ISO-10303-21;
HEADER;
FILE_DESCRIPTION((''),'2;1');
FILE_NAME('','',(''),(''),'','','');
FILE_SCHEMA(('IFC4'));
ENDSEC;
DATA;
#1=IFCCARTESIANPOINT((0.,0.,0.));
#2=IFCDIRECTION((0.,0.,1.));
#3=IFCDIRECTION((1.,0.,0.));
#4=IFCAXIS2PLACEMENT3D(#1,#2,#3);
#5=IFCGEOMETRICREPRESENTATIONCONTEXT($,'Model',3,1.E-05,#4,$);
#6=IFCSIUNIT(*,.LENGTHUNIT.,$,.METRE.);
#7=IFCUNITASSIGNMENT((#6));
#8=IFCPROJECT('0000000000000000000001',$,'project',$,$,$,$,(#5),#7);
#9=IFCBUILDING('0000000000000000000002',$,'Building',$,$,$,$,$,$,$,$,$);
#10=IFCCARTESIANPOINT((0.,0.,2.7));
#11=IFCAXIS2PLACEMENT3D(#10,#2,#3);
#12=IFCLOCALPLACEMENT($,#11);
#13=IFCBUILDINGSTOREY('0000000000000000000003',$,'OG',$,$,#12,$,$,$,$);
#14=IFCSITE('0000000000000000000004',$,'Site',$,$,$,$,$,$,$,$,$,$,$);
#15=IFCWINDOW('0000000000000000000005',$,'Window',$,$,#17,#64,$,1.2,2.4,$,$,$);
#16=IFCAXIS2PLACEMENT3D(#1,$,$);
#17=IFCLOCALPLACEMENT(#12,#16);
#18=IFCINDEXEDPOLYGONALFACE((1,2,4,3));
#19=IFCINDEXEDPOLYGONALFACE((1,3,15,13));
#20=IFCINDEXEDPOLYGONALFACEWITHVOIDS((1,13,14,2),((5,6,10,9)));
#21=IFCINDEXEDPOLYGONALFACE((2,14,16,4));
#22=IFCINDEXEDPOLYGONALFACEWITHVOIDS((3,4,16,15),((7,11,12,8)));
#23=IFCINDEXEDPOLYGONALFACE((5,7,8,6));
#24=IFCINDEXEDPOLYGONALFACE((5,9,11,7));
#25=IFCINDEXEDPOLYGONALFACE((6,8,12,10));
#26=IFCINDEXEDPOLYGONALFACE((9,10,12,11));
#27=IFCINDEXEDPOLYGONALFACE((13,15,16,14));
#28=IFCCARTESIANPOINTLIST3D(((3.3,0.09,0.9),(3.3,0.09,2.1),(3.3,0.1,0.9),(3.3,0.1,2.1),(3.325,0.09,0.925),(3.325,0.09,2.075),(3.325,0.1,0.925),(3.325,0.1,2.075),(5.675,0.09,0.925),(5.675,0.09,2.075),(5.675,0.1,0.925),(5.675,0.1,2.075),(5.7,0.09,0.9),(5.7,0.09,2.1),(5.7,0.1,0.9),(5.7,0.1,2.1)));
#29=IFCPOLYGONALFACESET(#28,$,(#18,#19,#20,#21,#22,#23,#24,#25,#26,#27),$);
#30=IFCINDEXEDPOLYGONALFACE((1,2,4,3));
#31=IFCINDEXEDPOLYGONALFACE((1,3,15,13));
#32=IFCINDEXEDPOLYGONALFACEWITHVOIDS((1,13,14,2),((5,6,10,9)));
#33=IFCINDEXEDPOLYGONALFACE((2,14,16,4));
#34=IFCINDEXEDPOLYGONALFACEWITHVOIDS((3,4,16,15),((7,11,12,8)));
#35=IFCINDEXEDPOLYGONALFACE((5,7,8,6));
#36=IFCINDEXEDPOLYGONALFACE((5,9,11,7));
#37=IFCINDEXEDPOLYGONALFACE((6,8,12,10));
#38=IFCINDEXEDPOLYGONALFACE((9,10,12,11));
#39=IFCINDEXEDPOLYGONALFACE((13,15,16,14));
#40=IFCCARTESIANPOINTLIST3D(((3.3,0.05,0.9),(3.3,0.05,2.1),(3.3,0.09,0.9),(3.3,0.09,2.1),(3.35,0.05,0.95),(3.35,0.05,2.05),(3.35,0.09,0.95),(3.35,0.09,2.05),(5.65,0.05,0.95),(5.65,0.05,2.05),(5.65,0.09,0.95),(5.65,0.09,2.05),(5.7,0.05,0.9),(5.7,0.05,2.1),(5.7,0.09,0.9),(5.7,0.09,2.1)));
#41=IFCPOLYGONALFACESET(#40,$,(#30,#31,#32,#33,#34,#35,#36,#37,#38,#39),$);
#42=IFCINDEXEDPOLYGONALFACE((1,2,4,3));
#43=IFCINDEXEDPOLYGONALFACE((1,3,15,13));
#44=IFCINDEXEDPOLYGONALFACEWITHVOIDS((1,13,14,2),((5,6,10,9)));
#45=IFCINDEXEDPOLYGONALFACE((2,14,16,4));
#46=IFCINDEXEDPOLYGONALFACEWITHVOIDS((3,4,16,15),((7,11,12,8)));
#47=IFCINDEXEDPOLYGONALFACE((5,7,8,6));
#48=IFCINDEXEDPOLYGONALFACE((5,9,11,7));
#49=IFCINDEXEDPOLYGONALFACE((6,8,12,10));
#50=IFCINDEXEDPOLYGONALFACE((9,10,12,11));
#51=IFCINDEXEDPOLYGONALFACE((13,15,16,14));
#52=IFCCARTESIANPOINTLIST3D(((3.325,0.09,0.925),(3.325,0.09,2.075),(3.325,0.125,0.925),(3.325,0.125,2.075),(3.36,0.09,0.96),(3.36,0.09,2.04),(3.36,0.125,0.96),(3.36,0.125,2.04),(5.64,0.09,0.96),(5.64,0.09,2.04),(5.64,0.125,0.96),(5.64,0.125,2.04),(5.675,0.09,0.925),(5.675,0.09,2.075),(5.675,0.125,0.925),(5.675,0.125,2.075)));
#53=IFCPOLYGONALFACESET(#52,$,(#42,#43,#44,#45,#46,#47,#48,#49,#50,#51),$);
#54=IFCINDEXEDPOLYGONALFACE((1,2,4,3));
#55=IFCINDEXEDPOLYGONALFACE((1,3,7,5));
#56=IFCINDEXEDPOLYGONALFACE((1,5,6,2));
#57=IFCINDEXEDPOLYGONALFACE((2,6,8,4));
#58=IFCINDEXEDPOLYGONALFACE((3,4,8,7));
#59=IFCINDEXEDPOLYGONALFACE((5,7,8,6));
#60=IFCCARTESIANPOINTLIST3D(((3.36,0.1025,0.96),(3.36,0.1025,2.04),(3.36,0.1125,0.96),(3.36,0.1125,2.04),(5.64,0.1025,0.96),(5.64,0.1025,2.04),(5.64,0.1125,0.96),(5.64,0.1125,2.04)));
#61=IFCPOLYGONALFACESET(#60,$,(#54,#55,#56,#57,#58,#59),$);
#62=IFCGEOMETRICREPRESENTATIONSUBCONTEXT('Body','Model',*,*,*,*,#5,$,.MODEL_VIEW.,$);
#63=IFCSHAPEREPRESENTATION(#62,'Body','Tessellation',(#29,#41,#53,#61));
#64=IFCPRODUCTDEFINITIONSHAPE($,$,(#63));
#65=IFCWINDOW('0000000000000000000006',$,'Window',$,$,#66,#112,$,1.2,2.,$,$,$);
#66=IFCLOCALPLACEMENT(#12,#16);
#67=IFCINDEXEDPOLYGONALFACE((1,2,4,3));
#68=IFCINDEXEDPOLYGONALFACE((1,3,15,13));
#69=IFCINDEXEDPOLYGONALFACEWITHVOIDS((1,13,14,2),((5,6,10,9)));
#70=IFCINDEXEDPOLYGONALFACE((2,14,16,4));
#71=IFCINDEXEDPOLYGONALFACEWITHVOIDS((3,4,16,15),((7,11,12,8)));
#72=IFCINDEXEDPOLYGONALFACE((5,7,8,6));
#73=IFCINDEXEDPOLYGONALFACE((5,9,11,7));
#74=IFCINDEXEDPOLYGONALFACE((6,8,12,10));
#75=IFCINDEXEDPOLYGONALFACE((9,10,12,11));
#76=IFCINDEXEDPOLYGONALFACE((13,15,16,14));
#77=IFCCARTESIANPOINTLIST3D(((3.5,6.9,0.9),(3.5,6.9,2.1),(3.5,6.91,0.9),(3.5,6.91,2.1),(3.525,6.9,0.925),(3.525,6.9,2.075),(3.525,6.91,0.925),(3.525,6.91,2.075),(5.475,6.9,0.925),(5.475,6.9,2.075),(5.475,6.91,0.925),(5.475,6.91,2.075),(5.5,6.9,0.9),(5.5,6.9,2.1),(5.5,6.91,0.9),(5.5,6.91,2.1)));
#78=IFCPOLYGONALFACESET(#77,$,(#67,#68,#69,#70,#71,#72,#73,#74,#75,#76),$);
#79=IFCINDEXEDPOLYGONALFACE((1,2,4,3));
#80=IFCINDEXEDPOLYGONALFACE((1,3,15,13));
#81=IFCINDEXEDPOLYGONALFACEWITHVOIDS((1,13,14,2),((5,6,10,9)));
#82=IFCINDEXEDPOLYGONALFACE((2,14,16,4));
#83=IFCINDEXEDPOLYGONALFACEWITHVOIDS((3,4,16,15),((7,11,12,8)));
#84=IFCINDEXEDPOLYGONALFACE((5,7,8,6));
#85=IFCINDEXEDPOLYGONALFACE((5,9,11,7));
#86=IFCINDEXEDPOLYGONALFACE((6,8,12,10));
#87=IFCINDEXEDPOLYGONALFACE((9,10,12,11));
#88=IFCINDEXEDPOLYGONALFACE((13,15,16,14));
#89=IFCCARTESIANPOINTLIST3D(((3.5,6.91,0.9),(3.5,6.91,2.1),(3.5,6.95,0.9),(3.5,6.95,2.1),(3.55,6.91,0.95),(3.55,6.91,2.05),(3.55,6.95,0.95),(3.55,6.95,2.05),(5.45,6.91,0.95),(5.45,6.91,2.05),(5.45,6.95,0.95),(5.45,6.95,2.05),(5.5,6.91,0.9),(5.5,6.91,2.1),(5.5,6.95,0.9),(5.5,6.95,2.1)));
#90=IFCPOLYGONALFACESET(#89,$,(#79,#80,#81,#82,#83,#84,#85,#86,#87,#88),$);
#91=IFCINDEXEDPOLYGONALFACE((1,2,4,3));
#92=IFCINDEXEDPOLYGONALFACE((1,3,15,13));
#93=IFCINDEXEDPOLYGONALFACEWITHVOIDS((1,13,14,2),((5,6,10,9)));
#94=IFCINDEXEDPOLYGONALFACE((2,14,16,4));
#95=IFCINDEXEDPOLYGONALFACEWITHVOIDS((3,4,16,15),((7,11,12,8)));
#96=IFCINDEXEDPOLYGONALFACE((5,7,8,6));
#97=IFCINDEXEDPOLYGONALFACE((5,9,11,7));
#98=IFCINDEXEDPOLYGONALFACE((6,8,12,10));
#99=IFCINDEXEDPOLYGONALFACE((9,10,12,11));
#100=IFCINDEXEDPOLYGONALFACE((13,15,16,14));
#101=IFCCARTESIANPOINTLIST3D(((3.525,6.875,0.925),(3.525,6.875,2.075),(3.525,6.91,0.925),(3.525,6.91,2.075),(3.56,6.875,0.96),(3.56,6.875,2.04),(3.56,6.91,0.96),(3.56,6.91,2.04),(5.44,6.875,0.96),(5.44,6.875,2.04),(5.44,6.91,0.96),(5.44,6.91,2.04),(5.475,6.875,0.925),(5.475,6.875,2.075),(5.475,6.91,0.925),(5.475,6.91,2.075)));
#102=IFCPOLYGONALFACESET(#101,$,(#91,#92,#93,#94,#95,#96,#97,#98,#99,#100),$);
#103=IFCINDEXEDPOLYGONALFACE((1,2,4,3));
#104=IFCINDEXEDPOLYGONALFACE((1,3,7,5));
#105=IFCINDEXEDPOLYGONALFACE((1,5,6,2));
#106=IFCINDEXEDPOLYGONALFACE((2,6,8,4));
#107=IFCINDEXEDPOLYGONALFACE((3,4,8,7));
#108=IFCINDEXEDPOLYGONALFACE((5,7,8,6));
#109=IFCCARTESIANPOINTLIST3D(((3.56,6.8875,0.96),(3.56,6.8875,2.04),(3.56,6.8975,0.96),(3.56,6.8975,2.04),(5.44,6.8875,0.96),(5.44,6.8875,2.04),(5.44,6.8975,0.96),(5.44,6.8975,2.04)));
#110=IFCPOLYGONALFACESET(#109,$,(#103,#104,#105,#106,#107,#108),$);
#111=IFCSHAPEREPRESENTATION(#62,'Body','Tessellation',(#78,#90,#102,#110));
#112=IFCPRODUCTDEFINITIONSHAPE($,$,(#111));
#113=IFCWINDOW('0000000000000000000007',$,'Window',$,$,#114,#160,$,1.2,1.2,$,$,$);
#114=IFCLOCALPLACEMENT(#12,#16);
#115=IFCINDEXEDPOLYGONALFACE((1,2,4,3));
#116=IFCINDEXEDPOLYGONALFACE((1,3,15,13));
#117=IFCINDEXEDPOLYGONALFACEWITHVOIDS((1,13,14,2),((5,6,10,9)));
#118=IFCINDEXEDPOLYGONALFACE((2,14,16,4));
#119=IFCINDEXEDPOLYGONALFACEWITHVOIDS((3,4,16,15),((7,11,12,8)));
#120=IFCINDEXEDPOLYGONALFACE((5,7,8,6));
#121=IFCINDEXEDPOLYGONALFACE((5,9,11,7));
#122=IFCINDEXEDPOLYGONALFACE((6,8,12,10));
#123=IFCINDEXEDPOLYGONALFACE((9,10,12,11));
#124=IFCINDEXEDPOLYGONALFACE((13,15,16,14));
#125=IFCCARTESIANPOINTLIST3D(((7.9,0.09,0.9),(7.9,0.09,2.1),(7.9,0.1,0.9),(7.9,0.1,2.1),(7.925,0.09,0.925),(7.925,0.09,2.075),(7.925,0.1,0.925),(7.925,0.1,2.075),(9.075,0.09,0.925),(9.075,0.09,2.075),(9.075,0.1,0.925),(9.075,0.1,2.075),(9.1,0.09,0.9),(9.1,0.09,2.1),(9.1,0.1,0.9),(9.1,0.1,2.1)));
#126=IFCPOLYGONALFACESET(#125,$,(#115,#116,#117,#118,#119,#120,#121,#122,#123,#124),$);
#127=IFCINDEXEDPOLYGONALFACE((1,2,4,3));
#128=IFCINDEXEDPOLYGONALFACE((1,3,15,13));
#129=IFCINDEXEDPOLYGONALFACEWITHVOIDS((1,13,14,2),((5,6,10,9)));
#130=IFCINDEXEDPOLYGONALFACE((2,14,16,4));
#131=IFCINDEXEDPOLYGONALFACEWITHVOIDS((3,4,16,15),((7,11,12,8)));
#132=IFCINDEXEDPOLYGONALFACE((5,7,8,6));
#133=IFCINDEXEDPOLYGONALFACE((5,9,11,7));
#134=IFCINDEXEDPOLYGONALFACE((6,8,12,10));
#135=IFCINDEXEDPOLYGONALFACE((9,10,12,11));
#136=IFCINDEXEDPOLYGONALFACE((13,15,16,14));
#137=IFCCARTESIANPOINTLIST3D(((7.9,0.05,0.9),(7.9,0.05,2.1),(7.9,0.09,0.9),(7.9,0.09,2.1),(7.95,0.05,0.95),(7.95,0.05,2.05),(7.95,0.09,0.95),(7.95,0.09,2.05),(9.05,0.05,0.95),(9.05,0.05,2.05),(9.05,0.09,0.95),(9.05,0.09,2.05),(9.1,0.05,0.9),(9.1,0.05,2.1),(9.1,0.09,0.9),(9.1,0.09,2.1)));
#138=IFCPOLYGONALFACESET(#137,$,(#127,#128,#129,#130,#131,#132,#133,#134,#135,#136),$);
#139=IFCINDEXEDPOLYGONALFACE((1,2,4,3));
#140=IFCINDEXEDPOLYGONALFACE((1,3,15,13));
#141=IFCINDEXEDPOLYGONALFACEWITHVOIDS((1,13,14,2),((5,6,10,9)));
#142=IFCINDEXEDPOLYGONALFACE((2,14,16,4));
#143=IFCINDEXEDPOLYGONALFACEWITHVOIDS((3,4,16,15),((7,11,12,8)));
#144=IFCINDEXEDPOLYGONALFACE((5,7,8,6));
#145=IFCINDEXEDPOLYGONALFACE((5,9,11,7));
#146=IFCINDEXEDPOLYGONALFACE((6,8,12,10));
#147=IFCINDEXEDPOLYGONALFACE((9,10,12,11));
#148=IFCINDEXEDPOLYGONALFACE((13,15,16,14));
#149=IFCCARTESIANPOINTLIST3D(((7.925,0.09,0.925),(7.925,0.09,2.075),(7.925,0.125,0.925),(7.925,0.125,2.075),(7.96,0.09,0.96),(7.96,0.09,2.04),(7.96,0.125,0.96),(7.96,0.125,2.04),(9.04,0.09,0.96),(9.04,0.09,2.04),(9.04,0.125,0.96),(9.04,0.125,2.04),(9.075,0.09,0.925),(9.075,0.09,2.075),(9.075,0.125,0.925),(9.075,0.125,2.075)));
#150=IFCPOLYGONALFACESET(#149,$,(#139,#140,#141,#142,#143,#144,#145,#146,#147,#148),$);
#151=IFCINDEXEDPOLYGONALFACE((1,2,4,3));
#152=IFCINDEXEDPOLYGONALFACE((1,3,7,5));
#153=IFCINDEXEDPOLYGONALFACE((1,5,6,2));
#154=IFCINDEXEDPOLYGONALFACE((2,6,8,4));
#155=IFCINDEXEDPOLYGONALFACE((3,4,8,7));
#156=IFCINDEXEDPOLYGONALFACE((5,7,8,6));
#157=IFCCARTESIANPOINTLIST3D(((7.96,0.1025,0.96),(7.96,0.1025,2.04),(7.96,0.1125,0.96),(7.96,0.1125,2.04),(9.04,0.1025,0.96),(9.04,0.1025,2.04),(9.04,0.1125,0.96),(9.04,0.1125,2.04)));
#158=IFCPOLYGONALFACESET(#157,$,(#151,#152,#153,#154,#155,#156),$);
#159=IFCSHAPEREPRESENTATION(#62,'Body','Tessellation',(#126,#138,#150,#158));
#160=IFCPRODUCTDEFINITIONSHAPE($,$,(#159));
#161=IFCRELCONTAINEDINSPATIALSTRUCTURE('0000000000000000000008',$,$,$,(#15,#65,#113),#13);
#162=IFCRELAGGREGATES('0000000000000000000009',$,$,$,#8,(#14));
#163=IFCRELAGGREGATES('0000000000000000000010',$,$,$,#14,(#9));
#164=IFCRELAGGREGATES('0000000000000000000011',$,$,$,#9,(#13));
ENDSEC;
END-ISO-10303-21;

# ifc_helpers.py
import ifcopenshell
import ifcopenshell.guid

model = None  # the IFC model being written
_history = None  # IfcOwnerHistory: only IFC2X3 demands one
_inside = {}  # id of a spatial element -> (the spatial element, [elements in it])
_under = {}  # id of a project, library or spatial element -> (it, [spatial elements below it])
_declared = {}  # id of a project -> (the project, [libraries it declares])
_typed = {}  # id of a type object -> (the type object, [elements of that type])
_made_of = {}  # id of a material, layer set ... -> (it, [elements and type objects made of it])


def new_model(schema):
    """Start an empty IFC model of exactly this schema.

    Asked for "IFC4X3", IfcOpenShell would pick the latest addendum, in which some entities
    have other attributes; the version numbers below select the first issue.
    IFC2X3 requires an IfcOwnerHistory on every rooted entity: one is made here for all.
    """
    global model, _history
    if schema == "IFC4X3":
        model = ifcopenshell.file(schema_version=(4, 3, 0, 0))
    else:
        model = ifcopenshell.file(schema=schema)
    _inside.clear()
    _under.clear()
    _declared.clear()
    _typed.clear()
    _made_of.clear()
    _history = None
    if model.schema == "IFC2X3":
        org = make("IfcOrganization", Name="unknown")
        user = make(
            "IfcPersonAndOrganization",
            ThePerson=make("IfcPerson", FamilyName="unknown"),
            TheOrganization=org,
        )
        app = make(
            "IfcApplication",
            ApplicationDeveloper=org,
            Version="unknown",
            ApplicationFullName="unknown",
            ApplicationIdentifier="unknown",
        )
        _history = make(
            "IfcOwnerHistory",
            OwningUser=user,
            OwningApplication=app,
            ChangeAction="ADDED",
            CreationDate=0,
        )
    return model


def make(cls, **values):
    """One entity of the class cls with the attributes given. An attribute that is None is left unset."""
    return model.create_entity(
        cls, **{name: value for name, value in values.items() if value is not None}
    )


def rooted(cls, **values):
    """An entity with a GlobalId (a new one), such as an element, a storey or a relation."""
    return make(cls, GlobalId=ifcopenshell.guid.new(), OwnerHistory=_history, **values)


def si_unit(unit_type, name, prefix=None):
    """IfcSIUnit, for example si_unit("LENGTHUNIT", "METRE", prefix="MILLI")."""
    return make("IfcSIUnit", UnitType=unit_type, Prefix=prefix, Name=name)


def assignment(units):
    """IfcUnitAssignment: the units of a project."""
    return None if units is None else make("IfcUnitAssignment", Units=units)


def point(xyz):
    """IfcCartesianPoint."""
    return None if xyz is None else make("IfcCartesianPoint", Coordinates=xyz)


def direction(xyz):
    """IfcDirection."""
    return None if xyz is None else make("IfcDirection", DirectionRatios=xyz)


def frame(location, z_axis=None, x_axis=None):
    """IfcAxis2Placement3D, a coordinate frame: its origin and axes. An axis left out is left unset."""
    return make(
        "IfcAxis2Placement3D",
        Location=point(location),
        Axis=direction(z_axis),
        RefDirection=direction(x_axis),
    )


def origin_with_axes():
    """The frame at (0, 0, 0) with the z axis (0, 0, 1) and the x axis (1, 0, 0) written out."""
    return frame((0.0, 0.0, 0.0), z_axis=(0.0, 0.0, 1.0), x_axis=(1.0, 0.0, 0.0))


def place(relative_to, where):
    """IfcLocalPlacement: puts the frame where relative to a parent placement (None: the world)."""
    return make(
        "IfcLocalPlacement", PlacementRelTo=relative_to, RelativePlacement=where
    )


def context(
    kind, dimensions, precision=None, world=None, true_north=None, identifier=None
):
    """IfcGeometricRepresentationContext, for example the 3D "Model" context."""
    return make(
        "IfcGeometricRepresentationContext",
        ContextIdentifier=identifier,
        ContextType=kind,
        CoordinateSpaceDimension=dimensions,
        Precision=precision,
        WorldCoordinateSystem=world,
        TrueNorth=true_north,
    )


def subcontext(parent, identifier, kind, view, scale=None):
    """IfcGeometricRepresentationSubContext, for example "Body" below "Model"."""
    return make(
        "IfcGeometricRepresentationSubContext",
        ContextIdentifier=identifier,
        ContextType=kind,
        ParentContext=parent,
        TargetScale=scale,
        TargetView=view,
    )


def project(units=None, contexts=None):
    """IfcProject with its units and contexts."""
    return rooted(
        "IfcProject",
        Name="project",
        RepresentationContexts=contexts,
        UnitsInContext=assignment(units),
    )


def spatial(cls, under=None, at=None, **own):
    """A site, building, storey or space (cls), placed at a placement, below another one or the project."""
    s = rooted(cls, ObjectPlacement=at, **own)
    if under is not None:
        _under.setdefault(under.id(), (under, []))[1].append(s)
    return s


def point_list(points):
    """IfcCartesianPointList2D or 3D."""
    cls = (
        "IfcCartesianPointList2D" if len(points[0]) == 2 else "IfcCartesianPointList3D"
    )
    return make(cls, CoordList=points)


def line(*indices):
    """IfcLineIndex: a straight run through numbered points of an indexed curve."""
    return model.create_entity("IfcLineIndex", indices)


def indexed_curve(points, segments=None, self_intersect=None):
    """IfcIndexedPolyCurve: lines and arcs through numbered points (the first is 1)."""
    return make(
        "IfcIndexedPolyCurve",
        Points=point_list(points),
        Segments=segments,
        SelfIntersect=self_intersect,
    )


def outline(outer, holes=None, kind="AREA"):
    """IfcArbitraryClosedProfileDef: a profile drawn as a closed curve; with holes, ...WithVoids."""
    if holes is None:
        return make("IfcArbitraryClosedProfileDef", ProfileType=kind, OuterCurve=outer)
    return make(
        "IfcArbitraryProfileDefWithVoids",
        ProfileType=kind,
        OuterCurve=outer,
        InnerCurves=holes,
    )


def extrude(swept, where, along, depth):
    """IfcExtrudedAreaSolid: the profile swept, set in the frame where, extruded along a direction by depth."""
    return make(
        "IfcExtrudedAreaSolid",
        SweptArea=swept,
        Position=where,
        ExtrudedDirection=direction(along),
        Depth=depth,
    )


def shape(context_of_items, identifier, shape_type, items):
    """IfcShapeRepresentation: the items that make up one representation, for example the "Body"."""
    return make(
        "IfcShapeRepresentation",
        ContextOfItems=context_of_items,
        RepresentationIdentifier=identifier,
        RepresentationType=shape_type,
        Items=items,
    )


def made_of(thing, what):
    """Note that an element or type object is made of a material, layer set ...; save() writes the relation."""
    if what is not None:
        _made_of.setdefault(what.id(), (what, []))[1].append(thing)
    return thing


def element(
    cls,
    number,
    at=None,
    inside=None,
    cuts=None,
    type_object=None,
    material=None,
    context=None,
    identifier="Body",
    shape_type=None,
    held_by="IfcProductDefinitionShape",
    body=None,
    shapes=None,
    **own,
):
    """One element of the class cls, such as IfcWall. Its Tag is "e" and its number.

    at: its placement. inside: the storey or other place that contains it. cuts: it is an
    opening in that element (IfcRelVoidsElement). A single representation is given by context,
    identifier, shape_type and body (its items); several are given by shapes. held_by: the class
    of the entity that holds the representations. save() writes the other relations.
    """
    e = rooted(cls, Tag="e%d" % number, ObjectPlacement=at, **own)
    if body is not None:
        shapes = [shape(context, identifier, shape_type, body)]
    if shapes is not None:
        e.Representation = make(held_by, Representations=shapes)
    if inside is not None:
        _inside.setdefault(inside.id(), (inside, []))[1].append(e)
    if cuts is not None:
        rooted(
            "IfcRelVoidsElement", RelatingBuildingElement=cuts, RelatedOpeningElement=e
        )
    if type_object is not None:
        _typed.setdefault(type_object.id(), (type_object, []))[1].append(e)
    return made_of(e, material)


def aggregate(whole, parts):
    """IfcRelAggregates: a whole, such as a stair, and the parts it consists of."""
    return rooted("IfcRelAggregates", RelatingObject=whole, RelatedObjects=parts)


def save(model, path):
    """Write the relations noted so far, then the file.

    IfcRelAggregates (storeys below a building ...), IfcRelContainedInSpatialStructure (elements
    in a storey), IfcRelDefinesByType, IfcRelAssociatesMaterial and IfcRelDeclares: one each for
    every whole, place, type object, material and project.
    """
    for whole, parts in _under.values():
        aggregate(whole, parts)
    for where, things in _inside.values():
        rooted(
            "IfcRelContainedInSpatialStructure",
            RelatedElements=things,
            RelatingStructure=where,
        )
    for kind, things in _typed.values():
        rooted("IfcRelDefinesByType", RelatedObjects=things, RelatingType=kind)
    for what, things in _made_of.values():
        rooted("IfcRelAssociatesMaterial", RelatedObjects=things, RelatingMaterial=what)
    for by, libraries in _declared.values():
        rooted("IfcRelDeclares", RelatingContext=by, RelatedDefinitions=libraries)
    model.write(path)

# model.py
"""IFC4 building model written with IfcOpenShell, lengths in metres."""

from ifc_helpers import new_model, si_unit, frame, origin_with_axes, place, context, subcontext, project, spatial, line, indexed_curve, outline, extrude, element, save


model = new_model("IFC4")

# Units and contexts
model_context = context("Model", 3, precision=1e-05, world=origin_with_axes())
body_context = subcontext(model_context, "Body", "Model", "MODEL_VIEW")
ifc_project = project(units=[si_unit("LENGTHUNIT", "METRE")], contexts=[model_context])

# Site, building, storey
site = spatial("IfcSite", under=ifc_project, Name="Site")
building = spatial("IfcBuilding", under=site, Name="Building")
storey_placement = place(None, frame((0.0, 0.0, 2.7), z_axis=(0.0, 0.0, 1.0), x_axis=(1.0, 0.0, 0.0)))
storey = spatial("IfcBuildingStorey", under=building, at=storey_placement, Name="OG")

# Windows
window_1_placement = place(storey_placement, frame((3.3, 0.0, 0.9), z_axis=(0.0, 0.0, 1.0), x_axis=(1.0, 0.0, 0.0)))
element("IfcWindow", 1, at=window_1_placement, inside=storey, Name="Window", OverallHeight=1.2, OverallWidth=2.4, context=body_context, shape_type="SweptSolid", body=[
    extrude(outline(indexed_curve([(0.0, 0.0), (2.4, 0.0), (2.4, 1.2), (0.0, 1.2)], segments=[line(1, 2, 3, 4, 1)]), holes=[indexed_curve([(0.025, 0.025), (2.375, 0.025), (2.375, 1.175), (0.025, 1.175)], segments=[line(1, 2, 3, 4, 1)])]), frame((0.0, 0.09, 0.0), z_axis=(0.0, -1.0, 0.0), x_axis=(1.0, 0.0, 0.0)), (0.0, 0.0, -1.0), 0.01),
    extrude(outline(indexed_curve([(0.0, 0.0), (2.4, 0.0), (2.4, 1.2), (0.0, 1.2)], segments=[line(1, 2, 3, 4, 1)]), holes=[indexed_curve([(0.05, 0.05), (2.35, 0.05), (2.35, 1.15), (0.05, 1.15)], segments=[line(1, 2, 3, 4, 1)])]), frame((0.0, 0.05, 0.0), z_axis=(0.0, -1.0, 0.0), x_axis=(1.0, 0.0, 0.0)), (0.0, 0.0, -1.0), 0.04),
    extrude(outline(indexed_curve([(0.0, 0.0), (2.35, 0.0), (2.35, 1.15), (0.0, 1.15)], segments=[line(1, 2, 3, 4, 1)]), holes=[indexed_curve([(0.035, 0.035), (2.315, 0.035), (2.315, 1.115), (0.035, 1.115)], segments=[line(1, 2, 3, 4, 1)])]), frame((0.025, 0.09, 0.025), z_axis=(0.0, -1.0, 0.0), x_axis=(1.0, 0.0, 0.0)), (0.0, 0.0, -1.0), 0.035),
    extrude(outline(indexed_curve([(0.035, 0.035), (2.315, 0.035), (2.315, 1.115), (0.035, 1.115)], segments=[line(1, 2, 3, 4, 1)])), frame((0.025, 0.1025, 0.025), z_axis=(0.0, -1.0, 0.0), x_axis=(1.0, 0.0, 0.0)), (0.0, 0.0, -1.0), 0.01),
])
window_2_placement = place(storey_placement, frame((5.5, 7.0, 0.9), z_axis=(0.0, 0.0, 1.0), x_axis=(-1.0, 0.0, 0.0)))
element("IfcWindow", 2, at=window_2_placement, inside=storey, Name="Window", OverallHeight=1.2, OverallWidth=2.0, context=body_context, shape_type="SweptSolid", body=[
    extrude(outline(indexed_curve([(0.0, 0.0), (2.0, 0.0), (2.0, 1.2), (0.0, 1.2)], segments=[line(1, 2, 3, 4, 1)]), holes=[indexed_curve([(0.025, 0.025), (1.975, 0.025), (1.975, 1.175), (0.025, 1.175)], segments=[line(1, 2, 3, 4, 1)])]), frame((0.0, 0.09, 0.0), z_axis=(0.0, -1.0, 0.0), x_axis=(1.0, 0.0, 0.0)), (0.0, 0.0, -1.0), 0.01),
    extrude(outline(indexed_curve([(0.0, 0.0), (2.0, 0.0), (2.0, 1.2), (0.0, 1.2)], segments=[line(1, 2, 3, 4, 1)]), holes=[indexed_curve([(0.05, 0.05), (1.95, 0.05), (1.95, 1.15), (0.05, 1.15)], segments=[line(1, 2, 3, 4, 1)])]), frame((0.0, 0.05, 0.0), z_axis=(0.0, -1.0, 0.0), x_axis=(1.0, 0.0, 0.0)), (0.0, 0.0, -1.0), 0.04),
    extrude(outline(indexed_curve([(0.0, 0.0), (1.95, 0.0), (1.95, 1.15), (0.0, 1.15)], segments=[line(1, 2, 3, 4, 1)]), holes=[indexed_curve([(0.035, 0.035), (1.915, 0.035), (1.915, 1.115), (0.035, 1.115)], segments=[line(1, 2, 3, 4, 1)])]), frame((0.025, 0.09, 0.025), z_axis=(0.0, -1.0, 0.0), x_axis=(1.0, 0.0, 0.0)), (0.0, 0.0, -1.0), 0.035),
    extrude(outline(indexed_curve([(0.035, 0.035), (1.915, 0.035), (1.915, 1.115), (0.035, 1.115)], segments=[line(1, 2, 3, 4, 1)])), frame((0.025, 0.1025, 0.025), z_axis=(0.0, -1.0, 0.0), x_axis=(1.0, 0.0, 0.0)), (0.0, 0.0, -1.0), 0.01),
])
window_3_placement = place(storey_placement, frame((7.9, 0.0, 0.9), z_axis=(0.0, 0.0, 1.0), x_axis=(1.0, 0.0, 0.0)))
element("IfcWindow", 3, at=window_3_placement, inside=storey, Name="Window", OverallHeight=1.2, OverallWidth=1.2, context=body_context, shape_type="SweptSolid", body=[
    extrude(outline(indexed_curve([(0.0, 0.0), (1.2, 0.0), (1.2, 1.2), (0.0, 1.2)], segments=[line(1, 2, 3, 4, 1)]), holes=[indexed_curve([(0.025, 0.025), (1.175, 0.025), (1.175, 1.175), (0.025, 1.175)], segments=[line(1, 2, 3, 4, 1)])]), frame((0.0, 0.09, 0.0), z_axis=(0.0, -1.0, 0.0), x_axis=(1.0, 0.0, 0.0)), (0.0, 0.0, -1.0), 0.01),
    extrude(outline(indexed_curve([(0.0, 0.0), (1.2, 0.0), (1.2, 1.2), (0.0, 1.2)], segments=[line(1, 2, 3, 4, 1)]), holes=[indexed_curve([(0.05, 0.05), (1.15, 0.05), (1.15, 1.15), (0.05, 1.15)], segments=[line(1, 2, 3, 4, 1)])]), frame((0.0, 0.05, 0.0), z_axis=(0.0, -1.0, 0.0), x_axis=(1.0, 0.0, 0.0)), (0.0, 0.0, -1.0), 0.04),
    extrude(outline(indexed_curve([(0.0, 0.0), (1.15, 0.0), (1.15, 1.15), (0.0, 1.15)], segments=[line(1, 2, 3, 4, 1)]), holes=[indexed_curve([(0.035, 0.035), (1.115, 0.035), (1.115, 1.115), (0.035, 1.115)], segments=[line(1, 2, 3, 4, 1)])]), frame((0.025, 0.09, 0.025), z_axis=(0.0, -1.0, 0.0), x_axis=(1.0, 0.0, 0.0)), (0.0, 0.0, -1.0), 0.035),
    extrude(outline(indexed_curve([(0.035, 0.035), (1.115, 0.035), (1.115, 1.115), (0.035, 1.115)], segments=[line(1, 2, 3, 4, 1)])), frame((0.025, 0.1025, 0.025), z_axis=(0.0, -1.0, 0.0), x_axis=(1.0, 0.0, 0.0)), (0.0, 0.0, -1.0), 0.01),
])

save(model, "model.ifc")
